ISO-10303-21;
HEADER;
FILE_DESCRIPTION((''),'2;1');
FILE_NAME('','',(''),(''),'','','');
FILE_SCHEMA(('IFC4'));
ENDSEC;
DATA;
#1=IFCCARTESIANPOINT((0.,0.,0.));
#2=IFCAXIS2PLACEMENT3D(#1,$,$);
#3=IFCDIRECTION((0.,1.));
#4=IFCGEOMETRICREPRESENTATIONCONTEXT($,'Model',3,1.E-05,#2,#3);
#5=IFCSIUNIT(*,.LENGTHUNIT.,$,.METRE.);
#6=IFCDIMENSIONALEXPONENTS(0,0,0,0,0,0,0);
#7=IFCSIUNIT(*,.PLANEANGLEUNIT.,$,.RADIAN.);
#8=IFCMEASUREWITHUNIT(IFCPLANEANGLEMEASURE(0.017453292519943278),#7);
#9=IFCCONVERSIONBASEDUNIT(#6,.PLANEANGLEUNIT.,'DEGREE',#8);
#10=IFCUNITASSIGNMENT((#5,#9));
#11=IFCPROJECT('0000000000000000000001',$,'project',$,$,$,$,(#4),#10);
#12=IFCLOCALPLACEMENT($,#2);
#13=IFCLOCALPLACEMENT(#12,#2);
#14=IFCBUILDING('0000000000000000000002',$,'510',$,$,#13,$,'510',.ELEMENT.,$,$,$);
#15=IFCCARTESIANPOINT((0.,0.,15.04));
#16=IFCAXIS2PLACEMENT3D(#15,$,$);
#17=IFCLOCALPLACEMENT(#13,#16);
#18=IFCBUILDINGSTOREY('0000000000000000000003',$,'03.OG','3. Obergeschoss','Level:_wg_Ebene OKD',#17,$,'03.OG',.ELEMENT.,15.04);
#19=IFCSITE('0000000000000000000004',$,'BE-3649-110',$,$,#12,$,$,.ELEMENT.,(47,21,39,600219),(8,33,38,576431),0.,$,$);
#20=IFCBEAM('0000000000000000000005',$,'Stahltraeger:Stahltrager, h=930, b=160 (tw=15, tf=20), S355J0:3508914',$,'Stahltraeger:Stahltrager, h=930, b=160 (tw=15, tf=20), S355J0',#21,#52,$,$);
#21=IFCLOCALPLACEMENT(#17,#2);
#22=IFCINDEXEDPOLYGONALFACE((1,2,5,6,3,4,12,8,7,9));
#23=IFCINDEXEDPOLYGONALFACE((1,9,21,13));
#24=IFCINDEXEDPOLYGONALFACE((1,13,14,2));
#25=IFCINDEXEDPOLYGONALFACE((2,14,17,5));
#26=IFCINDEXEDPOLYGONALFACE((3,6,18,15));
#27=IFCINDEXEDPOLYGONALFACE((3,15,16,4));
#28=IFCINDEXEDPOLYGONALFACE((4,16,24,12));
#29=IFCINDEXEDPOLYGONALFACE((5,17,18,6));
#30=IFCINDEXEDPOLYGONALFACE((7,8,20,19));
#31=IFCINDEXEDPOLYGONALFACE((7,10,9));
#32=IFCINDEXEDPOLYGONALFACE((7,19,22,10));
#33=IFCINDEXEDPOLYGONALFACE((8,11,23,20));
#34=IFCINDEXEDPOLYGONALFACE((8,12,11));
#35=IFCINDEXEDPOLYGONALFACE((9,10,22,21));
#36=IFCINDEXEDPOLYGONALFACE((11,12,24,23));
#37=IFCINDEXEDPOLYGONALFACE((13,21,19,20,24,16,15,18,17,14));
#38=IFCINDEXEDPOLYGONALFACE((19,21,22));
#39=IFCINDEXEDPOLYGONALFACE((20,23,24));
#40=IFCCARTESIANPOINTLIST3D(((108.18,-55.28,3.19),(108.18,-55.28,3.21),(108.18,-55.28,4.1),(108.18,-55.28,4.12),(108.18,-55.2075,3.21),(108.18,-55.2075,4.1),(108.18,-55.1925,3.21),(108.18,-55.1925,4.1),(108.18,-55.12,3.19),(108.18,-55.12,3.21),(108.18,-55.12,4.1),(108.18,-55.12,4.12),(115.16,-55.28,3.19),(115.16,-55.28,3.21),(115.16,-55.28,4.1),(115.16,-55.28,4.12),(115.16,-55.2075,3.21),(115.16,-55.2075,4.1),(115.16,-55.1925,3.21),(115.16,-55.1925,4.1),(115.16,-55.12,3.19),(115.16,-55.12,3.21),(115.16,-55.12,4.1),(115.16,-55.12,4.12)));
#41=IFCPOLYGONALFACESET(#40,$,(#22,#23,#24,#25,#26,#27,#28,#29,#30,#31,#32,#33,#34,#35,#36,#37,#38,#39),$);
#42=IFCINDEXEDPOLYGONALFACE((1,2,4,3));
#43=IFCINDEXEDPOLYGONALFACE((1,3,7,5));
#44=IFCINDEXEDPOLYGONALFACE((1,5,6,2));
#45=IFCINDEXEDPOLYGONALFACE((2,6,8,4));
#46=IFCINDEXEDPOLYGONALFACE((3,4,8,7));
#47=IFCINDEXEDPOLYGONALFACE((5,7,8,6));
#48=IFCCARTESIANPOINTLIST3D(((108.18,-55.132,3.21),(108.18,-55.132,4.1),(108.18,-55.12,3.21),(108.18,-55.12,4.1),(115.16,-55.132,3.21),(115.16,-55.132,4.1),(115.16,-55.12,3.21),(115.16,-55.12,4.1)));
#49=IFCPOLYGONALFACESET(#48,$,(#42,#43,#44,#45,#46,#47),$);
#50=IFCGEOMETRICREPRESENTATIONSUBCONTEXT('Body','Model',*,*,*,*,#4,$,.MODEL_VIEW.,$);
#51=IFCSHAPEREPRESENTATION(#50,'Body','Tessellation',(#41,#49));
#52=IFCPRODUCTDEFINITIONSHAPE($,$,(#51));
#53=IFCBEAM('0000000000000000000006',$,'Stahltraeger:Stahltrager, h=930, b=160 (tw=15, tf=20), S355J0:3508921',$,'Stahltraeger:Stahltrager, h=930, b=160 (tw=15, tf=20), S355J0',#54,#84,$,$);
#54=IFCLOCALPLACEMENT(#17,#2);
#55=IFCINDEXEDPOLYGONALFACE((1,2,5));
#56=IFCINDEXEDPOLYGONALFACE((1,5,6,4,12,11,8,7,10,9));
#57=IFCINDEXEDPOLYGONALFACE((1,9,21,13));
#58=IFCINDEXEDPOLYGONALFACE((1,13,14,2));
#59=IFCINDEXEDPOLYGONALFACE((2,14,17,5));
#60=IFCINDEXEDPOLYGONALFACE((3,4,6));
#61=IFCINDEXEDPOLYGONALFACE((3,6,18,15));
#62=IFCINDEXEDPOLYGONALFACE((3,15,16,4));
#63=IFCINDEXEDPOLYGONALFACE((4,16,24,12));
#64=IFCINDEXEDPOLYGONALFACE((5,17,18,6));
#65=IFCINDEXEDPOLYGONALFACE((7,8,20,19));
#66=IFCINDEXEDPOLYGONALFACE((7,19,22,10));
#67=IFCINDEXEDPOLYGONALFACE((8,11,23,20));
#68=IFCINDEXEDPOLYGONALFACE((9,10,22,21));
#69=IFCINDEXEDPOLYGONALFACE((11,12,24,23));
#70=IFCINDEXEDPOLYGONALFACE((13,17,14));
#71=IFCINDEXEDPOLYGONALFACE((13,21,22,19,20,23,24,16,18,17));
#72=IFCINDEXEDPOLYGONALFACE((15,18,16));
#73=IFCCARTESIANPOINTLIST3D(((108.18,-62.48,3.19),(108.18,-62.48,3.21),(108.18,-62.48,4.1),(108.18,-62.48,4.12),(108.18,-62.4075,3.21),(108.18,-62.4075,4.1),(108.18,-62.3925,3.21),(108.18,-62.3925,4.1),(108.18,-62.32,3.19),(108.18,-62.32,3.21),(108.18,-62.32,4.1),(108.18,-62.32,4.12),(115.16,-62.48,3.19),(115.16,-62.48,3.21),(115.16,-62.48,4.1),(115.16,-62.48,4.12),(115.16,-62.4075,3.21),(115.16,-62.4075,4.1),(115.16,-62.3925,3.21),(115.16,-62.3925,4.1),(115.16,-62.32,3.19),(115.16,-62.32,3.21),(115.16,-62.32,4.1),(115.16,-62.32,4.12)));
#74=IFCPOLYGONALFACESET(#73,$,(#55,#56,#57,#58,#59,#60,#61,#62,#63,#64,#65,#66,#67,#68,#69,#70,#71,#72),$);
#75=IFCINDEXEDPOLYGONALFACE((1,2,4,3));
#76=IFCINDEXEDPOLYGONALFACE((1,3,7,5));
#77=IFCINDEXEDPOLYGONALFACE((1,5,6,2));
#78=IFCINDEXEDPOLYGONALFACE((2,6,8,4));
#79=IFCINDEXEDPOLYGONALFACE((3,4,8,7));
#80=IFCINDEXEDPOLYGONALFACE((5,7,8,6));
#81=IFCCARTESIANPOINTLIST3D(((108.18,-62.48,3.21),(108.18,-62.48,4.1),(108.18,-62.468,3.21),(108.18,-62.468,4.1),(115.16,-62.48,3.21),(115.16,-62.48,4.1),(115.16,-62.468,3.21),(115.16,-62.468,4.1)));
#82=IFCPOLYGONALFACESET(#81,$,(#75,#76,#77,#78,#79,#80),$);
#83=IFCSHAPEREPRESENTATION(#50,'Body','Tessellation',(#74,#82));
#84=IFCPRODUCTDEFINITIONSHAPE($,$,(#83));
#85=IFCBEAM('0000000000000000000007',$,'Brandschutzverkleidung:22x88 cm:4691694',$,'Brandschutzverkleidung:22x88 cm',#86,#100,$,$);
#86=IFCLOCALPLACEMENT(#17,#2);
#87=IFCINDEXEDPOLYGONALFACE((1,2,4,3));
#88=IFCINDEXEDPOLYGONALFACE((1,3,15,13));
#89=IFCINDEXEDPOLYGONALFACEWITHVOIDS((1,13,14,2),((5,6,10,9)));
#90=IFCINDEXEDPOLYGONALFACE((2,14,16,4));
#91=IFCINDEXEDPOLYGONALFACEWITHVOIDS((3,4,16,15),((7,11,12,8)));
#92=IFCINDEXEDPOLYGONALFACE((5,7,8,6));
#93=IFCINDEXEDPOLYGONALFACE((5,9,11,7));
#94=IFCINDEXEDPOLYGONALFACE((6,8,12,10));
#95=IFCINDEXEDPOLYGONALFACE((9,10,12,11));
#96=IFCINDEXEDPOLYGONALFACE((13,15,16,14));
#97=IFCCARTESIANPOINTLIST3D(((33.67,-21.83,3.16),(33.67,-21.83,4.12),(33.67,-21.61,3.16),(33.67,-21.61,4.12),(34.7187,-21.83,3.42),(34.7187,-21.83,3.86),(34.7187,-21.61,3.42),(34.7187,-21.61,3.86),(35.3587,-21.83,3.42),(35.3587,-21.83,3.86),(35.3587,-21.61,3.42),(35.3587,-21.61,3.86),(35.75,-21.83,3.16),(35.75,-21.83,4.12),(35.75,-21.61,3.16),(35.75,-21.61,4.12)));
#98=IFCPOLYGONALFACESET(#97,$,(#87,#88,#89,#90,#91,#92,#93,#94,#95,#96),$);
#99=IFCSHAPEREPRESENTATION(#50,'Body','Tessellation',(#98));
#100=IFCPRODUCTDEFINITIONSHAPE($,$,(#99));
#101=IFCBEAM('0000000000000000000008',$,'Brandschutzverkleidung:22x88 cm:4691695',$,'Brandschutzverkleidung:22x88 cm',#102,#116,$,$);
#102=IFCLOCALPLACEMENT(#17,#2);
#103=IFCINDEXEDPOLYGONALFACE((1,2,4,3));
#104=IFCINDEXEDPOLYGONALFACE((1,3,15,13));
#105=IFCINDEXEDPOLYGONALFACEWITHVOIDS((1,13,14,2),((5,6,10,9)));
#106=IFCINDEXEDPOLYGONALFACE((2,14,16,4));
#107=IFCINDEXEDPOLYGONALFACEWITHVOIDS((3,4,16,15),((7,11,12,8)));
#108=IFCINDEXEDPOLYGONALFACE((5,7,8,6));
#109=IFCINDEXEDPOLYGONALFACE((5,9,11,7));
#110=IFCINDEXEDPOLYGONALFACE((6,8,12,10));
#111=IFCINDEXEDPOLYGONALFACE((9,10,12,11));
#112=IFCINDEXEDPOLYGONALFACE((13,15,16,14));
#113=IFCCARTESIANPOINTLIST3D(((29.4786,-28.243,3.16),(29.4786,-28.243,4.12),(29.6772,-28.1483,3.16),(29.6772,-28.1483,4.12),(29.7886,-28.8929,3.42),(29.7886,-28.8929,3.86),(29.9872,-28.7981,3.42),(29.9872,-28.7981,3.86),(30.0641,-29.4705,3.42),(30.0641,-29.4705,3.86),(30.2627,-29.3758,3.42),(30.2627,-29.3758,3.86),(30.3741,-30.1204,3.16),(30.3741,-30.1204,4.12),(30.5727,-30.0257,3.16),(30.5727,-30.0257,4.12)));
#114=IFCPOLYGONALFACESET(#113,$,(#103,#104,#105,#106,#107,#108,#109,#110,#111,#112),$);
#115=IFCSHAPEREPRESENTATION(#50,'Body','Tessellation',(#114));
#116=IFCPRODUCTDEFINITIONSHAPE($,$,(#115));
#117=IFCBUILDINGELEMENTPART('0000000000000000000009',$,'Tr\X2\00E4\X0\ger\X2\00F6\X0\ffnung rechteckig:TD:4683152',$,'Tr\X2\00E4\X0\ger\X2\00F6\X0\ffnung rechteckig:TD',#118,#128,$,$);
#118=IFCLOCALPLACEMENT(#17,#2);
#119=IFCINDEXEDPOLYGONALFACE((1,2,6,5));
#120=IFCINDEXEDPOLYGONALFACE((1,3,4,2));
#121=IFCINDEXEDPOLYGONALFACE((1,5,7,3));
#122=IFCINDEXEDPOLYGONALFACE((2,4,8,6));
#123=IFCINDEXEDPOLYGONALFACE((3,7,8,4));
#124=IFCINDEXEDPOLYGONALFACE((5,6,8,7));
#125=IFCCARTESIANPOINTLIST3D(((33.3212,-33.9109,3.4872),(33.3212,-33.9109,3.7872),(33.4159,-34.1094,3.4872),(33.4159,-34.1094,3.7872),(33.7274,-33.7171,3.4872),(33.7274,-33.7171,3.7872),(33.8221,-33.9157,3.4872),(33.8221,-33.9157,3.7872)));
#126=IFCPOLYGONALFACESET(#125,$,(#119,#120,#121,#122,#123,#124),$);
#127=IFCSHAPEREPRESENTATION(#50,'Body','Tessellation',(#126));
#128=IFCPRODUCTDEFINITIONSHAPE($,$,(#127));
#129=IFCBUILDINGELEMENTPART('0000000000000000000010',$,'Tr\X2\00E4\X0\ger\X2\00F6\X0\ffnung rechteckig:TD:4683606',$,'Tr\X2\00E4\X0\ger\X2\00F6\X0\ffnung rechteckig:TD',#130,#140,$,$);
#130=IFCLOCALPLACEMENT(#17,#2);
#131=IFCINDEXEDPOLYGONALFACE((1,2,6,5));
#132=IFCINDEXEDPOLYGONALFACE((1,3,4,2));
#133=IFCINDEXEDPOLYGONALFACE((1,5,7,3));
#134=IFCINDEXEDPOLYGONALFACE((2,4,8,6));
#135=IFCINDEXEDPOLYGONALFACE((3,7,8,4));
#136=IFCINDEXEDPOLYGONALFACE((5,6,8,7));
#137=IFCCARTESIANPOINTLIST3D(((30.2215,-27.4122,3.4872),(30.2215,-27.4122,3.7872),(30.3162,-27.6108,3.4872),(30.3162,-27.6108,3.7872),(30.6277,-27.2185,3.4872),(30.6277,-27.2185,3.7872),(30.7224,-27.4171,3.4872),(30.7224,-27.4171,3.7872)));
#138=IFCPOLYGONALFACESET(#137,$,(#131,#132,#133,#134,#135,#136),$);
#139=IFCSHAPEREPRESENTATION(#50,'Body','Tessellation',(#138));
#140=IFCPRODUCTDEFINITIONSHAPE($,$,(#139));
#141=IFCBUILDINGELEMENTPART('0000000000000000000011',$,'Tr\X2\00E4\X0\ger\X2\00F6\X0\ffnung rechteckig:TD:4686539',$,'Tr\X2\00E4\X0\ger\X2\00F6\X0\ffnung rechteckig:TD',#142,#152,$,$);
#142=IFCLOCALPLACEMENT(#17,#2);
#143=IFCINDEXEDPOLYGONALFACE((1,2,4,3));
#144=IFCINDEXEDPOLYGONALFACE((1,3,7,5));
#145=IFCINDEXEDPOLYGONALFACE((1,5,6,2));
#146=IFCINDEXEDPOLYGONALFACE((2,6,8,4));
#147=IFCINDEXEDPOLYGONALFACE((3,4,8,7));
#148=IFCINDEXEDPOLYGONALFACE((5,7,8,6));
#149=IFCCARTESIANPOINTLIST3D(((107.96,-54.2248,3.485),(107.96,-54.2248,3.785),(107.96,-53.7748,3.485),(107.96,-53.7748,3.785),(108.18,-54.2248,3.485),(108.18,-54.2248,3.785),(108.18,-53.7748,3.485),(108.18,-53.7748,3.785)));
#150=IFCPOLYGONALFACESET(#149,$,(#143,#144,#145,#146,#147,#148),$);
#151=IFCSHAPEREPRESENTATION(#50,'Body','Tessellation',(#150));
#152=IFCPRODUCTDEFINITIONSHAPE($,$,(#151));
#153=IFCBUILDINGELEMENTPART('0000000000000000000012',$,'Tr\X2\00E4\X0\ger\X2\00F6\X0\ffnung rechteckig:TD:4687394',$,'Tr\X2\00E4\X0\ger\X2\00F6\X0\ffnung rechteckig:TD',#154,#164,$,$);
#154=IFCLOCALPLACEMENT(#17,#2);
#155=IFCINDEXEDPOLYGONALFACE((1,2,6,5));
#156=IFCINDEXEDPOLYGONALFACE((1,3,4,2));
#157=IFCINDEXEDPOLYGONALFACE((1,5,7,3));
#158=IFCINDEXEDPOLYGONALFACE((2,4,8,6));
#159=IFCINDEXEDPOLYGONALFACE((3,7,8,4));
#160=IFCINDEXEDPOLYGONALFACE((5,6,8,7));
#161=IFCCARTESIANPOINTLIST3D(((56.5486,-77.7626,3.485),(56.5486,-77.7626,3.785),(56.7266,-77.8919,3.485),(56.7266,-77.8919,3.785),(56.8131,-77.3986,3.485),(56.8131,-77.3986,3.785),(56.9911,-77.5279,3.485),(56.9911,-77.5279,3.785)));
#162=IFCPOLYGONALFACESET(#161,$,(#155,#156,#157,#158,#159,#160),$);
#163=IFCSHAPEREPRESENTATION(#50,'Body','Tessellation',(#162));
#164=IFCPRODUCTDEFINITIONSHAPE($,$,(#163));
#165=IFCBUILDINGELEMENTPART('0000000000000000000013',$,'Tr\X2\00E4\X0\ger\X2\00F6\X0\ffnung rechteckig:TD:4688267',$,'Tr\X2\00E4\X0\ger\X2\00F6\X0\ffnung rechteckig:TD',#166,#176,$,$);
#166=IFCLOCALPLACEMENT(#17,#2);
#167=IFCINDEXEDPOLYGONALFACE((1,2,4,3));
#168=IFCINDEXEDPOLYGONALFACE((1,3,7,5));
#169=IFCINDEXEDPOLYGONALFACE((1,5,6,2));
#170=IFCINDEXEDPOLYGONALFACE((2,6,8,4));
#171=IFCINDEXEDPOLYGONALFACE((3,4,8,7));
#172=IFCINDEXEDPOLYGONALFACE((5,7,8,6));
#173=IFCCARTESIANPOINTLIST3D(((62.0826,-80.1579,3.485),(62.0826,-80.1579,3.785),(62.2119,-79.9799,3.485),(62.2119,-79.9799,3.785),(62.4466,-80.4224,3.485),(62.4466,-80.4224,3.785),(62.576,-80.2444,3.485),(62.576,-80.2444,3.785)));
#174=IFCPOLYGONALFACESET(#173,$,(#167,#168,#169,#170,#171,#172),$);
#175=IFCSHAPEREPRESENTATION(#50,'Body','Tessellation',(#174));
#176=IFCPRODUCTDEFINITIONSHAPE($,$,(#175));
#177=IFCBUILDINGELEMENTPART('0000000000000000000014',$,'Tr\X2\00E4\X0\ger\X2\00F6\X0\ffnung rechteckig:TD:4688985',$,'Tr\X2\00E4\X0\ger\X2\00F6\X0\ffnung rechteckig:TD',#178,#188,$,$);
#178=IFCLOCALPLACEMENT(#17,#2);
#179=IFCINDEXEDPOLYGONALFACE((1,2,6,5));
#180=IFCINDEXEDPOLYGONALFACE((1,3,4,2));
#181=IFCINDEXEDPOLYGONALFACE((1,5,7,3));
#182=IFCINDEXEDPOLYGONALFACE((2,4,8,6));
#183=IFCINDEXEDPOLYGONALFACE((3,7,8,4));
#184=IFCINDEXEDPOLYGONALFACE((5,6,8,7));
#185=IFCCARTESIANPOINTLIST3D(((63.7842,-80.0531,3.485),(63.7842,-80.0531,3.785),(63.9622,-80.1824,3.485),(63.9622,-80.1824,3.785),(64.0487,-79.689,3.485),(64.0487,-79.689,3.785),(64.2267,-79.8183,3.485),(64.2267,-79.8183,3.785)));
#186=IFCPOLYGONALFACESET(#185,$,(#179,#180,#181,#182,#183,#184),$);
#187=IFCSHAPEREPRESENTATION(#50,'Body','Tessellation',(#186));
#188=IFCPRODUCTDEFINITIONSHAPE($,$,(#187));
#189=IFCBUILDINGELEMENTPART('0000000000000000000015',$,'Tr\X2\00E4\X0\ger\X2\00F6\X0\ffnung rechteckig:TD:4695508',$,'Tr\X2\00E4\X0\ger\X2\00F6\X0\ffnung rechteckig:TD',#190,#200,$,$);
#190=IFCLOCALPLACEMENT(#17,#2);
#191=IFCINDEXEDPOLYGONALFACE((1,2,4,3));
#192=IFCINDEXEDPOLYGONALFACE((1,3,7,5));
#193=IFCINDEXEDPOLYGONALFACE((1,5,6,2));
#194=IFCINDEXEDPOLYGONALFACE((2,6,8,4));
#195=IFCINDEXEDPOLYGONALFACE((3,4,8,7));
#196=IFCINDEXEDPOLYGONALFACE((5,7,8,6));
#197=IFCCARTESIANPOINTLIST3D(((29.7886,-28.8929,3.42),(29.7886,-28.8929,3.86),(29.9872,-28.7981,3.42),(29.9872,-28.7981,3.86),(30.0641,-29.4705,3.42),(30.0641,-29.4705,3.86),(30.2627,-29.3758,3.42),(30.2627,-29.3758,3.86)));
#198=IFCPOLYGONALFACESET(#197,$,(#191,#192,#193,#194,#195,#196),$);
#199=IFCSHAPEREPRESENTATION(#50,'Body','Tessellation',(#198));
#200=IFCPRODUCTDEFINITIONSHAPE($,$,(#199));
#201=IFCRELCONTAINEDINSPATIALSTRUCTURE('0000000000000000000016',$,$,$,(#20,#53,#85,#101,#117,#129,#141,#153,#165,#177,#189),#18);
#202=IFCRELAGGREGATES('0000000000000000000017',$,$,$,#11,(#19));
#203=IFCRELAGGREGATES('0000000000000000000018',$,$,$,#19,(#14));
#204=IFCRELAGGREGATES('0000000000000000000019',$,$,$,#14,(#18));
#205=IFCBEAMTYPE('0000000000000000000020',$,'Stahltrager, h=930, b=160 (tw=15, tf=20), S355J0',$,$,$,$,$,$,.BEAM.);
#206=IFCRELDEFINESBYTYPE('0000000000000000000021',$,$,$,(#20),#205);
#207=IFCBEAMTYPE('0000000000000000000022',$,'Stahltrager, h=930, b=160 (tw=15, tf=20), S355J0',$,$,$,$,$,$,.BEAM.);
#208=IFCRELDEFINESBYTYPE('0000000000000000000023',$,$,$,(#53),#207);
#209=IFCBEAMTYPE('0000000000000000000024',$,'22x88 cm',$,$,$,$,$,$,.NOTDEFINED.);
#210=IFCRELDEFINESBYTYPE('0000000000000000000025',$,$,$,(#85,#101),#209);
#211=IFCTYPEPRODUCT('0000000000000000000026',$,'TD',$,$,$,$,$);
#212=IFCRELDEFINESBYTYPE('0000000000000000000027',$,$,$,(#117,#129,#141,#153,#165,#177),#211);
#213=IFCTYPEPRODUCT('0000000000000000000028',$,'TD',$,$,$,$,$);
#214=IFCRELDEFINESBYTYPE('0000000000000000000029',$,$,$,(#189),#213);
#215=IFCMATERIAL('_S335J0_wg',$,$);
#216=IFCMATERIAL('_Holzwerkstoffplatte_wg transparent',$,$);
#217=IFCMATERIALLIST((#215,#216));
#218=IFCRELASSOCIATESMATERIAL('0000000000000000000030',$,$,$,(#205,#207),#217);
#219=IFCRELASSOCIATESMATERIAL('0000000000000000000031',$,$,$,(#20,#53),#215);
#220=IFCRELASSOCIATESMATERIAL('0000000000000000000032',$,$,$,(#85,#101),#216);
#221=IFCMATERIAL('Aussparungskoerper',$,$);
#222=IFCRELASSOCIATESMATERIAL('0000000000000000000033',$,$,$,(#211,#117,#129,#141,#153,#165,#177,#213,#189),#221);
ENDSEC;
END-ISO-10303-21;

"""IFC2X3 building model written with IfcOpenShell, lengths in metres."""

from ifc_helpers import new_model, entity, si_unit, converted_unit, direction, frame, frame_2d, origin, origin_2d_with_axis, place, context, subcontext, project, spatial, polyline, rectangle, i_section, outline, extrude, source, transform, mapped, material, material_list, type_object, type_shapes, element, save


model = new_model("IFC2X3")

# Units and contexts
model_context = context("Model", 3, precision=1e-05, world=origin(), true_north=direction((0.0, 1.0)))
body_context = subcontext(model_context, "Body", "Model", "MODEL_VIEW")
ifc_project = project(units=[si_unit("LENGTHUNIT", "METRE"), converted_unit("PLANEANGLEUNIT", "DEGREE", entity("IfcPlaneAngleMeasure", 0.017453292519943278), si_unit("PLANEANGLEUNIT", "RADIAN"), dimensions=[0, 0, 0, 0, 0, 0, 0])], contexts=[model_context])

# Site, building, storey
site_placement = place(None, origin())
site = spatial("IfcSite", under=ifc_project, at=site_placement, Name="BE-3649-110", CompositionType="ELEMENT", RefLatitude=(47, 21, 39, 600219), RefLongitude=(8, 33, 38, 576431), RefElevation=0.0)
building_placement = place(site_placement, origin())
building = spatial("IfcBuilding", under=site, at=building_placement, Name="510", LongName="510", CompositionType="ELEMENT")
storey_placement = place(building_placement, frame((0.0, 0.0, 15.04)))
storey = spatial("IfcBuildingStorey", under=building, at=storey_placement, Name="03.OG", Description="3. Obergeschoss", ObjectType="Level:_wg_Ebene OKD", LongName="03.OG", CompositionType="ELEMENT", Elevation=15.04)

# Beams
ifc_material_1 = material(Name="_S335J0_wg")
ifc_material_2 = material(Name="_Holzwerkstoffplatte_wg transparent")
ifc_material_list = material_list([ifc_material_1, ifc_material_2])
beam_type_1 = type_object("IfcBeamType", Name="Stahltrager, h=930, b=160 (tw=15, tf=20), S355J0", PredefinedType="BEAM", material=ifc_material_list)
shared_shape_1 = source(origin(), body_context, "Body", "SweptSolid", [
    extrude(i_section(OverallWidth=0.16, OverallDepth=0.93, WebThickness=0.015, FlangeThickness=0.02, at=frame_2d((0.0, 0.0), x_axis=(0.0, 1.0))), frame((-3.49, 0.0, 0.0), z_axis=(1.0, 0.0, 0.0), x_axis=(0.0, 0.0, -1.0)), (0.0, 0.0, 1.0), 6.98),
    extrude(rectangle(XDim=0.89, YDim=0.012, at=origin_2d_with_axis()), frame((-3.49, 0.074, 0.0), z_axis=(1.0, 0.0, 0.0), x_axis=(0.0, 0.0, -1.0)), (0.0, 0.0, 1.0), 6.98),
])
type_shapes(beam_type_1, [shared_shape_1])
beam_1_placement = place(storey_placement, frame((111.67, -55.2, 3.655)))
element("IfcBeam", 1, at=beam_1_placement, inside=storey, type_object=beam_type_1, material=ifc_material_1, Name="Stahltraeger:Stahltrager, h=930, b=160 (tw=15, tf=20), S355J0:3508914", ObjectType="Stahltraeger:Stahltrager, h=930, b=160 (tw=15, tf=20), S355J0", context=body_context, shape_type="MappedRepresentation", body=[
    mapped(shared_shape_1, transform((0.0, 0.0, 0.0), scale=1.0)),
])
beam_type_2 = type_object("IfcBeamType", Name="Stahltrager, h=930, b=160 (tw=15, tf=20), S355J0", PredefinedType="BEAM", material=ifc_material_list)
shared_shape_2 = source(origin(), body_context, "Body", "SweptSolid", [
    extrude(i_section(OverallWidth=0.16, OverallDepth=0.93, WebThickness=0.015, FlangeThickness=0.02, at=frame_2d((0.0, 0.0), x_axis=(0.0, 1.0))), frame((-3.49, 0.0, 0.0), z_axis=(1.0, 0.0, 0.0), x_axis=(0.0, 0.0, -1.0)), (0.0, 0.0, 1.0), 6.98),
    extrude(rectangle(XDim=0.89, YDim=0.012, at=frame_2d((0.0, 0.0), x_axis=(1.0, 0.0))), frame((-3.49, -0.074, 0.0), z_axis=(1.0, 0.0, 0.0), x_axis=(0.0, 0.0, -1.0)), (0.0, 0.0, 1.0), 6.98),
])
type_shapes(beam_type_2, [shared_shape_2])
beam_2_placement = place(storey_placement, frame((111.67, -62.4, 3.655)))
element("IfcBeam", 2, at=beam_2_placement, inside=storey, type_object=beam_type_2, material=ifc_material_1, Name="Stahltraeger:Stahltrager, h=930, b=160 (tw=15, tf=20), S355J0:3508921", ObjectType="Stahltraeger:Stahltrager, h=930, b=160 (tw=15, tf=20), S355J0", context=body_context, shape_type="MappedRepresentation", body=[
    mapped(shared_shape_2, transform((0.0, 0.0, 0.0), scale=1.0)),
])
beam_type_3 = type_object("IfcBeamType", Name="22x88 cm", PredefinedType="NOTDEFINED")
beam_3_placement = place(storey_placement, frame((0.0, 0.0, 3.64)))
element("IfcBeam", 3, at=beam_3_placement, inside=storey, type_object=beam_type_3, material=ifc_material_2, Name="Brandschutzverkleidung:22x88 cm:4691694", ObjectType="Brandschutzverkleidung:22x88 cm", context=body_context, shape_type="SweptSolid", body=[
    extrude(outline(polyline([(-1.04, -0.48), (1.04, -0.48), (1.04, 0.48), (-1.04, 0.48), (-1.04, -0.48)]), holes=[polyline([(0.6487, 0.22), (0.6487, -0.22), (0.0087, -0.22), (0.0087, 0.22), (0.6487, 0.22)])]), frame((34.71, -21.83, 0.0), z_axis=(0.0, 1.0, 0.0), x_axis=(1.0, 0.0, 0.0)), (0.0, 0.0, 1.0), 0.22),
])
beam_4_placement = place(storey_placement, frame((0.0, 0.0, 3.64)))
element("IfcBeam", 4, at=beam_4_placement, inside=storey, type_object=beam_type_3, material=ifc_material_2, Name="Brandschutzverkleidung:22x88 cm:4691695", ObjectType="Brandschutzverkleidung:22x88 cm", context=body_context, shape_type="SweptSolid", body=[
    extrude(outline(polyline([(-1.04, -0.48), (1.04, -0.48), (1.04, 0.48), (-1.04, 0.48), (-1.04, -0.48)]), holes=[polyline([(-0.32, -0.22), (-0.32, 0.22), (0.32, 0.22), (0.32, -0.22), (-0.32, -0.22)])]), frame((29.9264, -29.1817, 0.0), z_axis=(0.902585, 0.430511, 0.0), x_axis=(-0.430511, 0.902585, 0.0)), (0.0, 0.0, 1.0), 0.22),
])

# Building element parts
ifc_material_3 = material(Name="Aussparungskoerper")
type_product_1 = type_object("IfcTypeProduct", Name="TD", material=ifc_material_3)
shared_shape_3 = source(origin(), body_context, "Body", "SweptSolid", [
    extrude(rectangle(XDim=0.45, YDim=0.3, at=origin_2d_with_axis()), frame((0.0, 0.0, -0.22), z_axis=(0.0, 0.0, 1.0), x_axis=(-1.0, 0.0, 0.0)), (0.0, 0.0, 1.0), 0.22),
])
type_shapes(type_product_1, [shared_shape_3])
for number, where, z_axis, x_axis, name in (
    (5, (33.619, -34.0126, 3.6372), (0.430511, -0.902585, 0.0), (-0.902585, -0.430511, 0.0), "Trägeröffnung rechteckig:TD:4683152"),
    (6, (30.5193, -27.5139, 3.6372), (0.430511, -0.902585, 0.0), (-0.902585, -0.430511, 0.0), "Trägeröffnung rechteckig:TD:4683606"),
    (7, (107.96, -53.9998, 3.635), (-1.0, 0.0, 0.0), (0.0, -1.0, 0.0), "Trägeröffnung rechteckig:TD:4686539"),
    (8, (56.8588, -77.7099, 3.635), (0.809017, -0.587785, 0.0), (-0.587785, -0.809017, 0.0), "Trägeröffnung rechteckig:TD:4687394"),
    (9, (62.2646, -80.2901, 3.635), (-0.587785, -0.809017, 0.0), (0.809017, -0.587785, 0.0), "Trägeröffnung rechteckig:TD:4688267"),
    (10, (64.0944, -80.0003, 3.635), (0.809017, -0.587785, 0.0), (-0.587785, -0.809017, 0.0), "Trägeröffnung rechteckig:TD:4688985"),
):
    element("IfcBuildingElementPart", number, at=place(storey_placement, frame(where, z_axis=z_axis, x_axis=x_axis)), inside=storey, type_object=type_product_1, material=ifc_material_3, Name=name, ObjectType="Trägeröffnung rechteckig:TD", context=body_context, shape_type="MappedRepresentation", body=[
        mapped(shared_shape_3, transform((0.0, 0.0, 0.0), scale=1.0)),
    ])
type_product_2 = type_object("IfcTypeProduct", Name="TD", material=ifc_material_3)
shared_shape_4 = source(origin(), body_context, "Body", "SweptSolid", [
    extrude(rectangle(XDim=0.22, YDim=0.64, at=origin_2d_with_axis()), frame((30.0256, -29.1343, -0.44), z_axis=(0.0, 0.0, 1.0), x_axis=(-0.902585, -0.430511, 0.0)), (0.0, 0.0, 1.0), 0.44),
])
type_shapes(type_product_2, [shared_shape_4])
building_element_part_1_placement = place(storey_placement, frame((0.0, 0.0, 3.86)))
element("IfcBuildingElementPart", 11, at=building_element_part_1_placement, inside=storey, type_object=type_product_2, material=ifc_material_3, Name="Trägeröffnung rechteckig:TD:4695508", ObjectType="Trägeröffnung rechteckig:TD", context=body_context, shape_type="MappedRepresentation", body=[
    mapped(shared_shape_4, transform((0.0, 0.0, 0.0), scale=1.0)),
])

save(model, "model.ifc")
